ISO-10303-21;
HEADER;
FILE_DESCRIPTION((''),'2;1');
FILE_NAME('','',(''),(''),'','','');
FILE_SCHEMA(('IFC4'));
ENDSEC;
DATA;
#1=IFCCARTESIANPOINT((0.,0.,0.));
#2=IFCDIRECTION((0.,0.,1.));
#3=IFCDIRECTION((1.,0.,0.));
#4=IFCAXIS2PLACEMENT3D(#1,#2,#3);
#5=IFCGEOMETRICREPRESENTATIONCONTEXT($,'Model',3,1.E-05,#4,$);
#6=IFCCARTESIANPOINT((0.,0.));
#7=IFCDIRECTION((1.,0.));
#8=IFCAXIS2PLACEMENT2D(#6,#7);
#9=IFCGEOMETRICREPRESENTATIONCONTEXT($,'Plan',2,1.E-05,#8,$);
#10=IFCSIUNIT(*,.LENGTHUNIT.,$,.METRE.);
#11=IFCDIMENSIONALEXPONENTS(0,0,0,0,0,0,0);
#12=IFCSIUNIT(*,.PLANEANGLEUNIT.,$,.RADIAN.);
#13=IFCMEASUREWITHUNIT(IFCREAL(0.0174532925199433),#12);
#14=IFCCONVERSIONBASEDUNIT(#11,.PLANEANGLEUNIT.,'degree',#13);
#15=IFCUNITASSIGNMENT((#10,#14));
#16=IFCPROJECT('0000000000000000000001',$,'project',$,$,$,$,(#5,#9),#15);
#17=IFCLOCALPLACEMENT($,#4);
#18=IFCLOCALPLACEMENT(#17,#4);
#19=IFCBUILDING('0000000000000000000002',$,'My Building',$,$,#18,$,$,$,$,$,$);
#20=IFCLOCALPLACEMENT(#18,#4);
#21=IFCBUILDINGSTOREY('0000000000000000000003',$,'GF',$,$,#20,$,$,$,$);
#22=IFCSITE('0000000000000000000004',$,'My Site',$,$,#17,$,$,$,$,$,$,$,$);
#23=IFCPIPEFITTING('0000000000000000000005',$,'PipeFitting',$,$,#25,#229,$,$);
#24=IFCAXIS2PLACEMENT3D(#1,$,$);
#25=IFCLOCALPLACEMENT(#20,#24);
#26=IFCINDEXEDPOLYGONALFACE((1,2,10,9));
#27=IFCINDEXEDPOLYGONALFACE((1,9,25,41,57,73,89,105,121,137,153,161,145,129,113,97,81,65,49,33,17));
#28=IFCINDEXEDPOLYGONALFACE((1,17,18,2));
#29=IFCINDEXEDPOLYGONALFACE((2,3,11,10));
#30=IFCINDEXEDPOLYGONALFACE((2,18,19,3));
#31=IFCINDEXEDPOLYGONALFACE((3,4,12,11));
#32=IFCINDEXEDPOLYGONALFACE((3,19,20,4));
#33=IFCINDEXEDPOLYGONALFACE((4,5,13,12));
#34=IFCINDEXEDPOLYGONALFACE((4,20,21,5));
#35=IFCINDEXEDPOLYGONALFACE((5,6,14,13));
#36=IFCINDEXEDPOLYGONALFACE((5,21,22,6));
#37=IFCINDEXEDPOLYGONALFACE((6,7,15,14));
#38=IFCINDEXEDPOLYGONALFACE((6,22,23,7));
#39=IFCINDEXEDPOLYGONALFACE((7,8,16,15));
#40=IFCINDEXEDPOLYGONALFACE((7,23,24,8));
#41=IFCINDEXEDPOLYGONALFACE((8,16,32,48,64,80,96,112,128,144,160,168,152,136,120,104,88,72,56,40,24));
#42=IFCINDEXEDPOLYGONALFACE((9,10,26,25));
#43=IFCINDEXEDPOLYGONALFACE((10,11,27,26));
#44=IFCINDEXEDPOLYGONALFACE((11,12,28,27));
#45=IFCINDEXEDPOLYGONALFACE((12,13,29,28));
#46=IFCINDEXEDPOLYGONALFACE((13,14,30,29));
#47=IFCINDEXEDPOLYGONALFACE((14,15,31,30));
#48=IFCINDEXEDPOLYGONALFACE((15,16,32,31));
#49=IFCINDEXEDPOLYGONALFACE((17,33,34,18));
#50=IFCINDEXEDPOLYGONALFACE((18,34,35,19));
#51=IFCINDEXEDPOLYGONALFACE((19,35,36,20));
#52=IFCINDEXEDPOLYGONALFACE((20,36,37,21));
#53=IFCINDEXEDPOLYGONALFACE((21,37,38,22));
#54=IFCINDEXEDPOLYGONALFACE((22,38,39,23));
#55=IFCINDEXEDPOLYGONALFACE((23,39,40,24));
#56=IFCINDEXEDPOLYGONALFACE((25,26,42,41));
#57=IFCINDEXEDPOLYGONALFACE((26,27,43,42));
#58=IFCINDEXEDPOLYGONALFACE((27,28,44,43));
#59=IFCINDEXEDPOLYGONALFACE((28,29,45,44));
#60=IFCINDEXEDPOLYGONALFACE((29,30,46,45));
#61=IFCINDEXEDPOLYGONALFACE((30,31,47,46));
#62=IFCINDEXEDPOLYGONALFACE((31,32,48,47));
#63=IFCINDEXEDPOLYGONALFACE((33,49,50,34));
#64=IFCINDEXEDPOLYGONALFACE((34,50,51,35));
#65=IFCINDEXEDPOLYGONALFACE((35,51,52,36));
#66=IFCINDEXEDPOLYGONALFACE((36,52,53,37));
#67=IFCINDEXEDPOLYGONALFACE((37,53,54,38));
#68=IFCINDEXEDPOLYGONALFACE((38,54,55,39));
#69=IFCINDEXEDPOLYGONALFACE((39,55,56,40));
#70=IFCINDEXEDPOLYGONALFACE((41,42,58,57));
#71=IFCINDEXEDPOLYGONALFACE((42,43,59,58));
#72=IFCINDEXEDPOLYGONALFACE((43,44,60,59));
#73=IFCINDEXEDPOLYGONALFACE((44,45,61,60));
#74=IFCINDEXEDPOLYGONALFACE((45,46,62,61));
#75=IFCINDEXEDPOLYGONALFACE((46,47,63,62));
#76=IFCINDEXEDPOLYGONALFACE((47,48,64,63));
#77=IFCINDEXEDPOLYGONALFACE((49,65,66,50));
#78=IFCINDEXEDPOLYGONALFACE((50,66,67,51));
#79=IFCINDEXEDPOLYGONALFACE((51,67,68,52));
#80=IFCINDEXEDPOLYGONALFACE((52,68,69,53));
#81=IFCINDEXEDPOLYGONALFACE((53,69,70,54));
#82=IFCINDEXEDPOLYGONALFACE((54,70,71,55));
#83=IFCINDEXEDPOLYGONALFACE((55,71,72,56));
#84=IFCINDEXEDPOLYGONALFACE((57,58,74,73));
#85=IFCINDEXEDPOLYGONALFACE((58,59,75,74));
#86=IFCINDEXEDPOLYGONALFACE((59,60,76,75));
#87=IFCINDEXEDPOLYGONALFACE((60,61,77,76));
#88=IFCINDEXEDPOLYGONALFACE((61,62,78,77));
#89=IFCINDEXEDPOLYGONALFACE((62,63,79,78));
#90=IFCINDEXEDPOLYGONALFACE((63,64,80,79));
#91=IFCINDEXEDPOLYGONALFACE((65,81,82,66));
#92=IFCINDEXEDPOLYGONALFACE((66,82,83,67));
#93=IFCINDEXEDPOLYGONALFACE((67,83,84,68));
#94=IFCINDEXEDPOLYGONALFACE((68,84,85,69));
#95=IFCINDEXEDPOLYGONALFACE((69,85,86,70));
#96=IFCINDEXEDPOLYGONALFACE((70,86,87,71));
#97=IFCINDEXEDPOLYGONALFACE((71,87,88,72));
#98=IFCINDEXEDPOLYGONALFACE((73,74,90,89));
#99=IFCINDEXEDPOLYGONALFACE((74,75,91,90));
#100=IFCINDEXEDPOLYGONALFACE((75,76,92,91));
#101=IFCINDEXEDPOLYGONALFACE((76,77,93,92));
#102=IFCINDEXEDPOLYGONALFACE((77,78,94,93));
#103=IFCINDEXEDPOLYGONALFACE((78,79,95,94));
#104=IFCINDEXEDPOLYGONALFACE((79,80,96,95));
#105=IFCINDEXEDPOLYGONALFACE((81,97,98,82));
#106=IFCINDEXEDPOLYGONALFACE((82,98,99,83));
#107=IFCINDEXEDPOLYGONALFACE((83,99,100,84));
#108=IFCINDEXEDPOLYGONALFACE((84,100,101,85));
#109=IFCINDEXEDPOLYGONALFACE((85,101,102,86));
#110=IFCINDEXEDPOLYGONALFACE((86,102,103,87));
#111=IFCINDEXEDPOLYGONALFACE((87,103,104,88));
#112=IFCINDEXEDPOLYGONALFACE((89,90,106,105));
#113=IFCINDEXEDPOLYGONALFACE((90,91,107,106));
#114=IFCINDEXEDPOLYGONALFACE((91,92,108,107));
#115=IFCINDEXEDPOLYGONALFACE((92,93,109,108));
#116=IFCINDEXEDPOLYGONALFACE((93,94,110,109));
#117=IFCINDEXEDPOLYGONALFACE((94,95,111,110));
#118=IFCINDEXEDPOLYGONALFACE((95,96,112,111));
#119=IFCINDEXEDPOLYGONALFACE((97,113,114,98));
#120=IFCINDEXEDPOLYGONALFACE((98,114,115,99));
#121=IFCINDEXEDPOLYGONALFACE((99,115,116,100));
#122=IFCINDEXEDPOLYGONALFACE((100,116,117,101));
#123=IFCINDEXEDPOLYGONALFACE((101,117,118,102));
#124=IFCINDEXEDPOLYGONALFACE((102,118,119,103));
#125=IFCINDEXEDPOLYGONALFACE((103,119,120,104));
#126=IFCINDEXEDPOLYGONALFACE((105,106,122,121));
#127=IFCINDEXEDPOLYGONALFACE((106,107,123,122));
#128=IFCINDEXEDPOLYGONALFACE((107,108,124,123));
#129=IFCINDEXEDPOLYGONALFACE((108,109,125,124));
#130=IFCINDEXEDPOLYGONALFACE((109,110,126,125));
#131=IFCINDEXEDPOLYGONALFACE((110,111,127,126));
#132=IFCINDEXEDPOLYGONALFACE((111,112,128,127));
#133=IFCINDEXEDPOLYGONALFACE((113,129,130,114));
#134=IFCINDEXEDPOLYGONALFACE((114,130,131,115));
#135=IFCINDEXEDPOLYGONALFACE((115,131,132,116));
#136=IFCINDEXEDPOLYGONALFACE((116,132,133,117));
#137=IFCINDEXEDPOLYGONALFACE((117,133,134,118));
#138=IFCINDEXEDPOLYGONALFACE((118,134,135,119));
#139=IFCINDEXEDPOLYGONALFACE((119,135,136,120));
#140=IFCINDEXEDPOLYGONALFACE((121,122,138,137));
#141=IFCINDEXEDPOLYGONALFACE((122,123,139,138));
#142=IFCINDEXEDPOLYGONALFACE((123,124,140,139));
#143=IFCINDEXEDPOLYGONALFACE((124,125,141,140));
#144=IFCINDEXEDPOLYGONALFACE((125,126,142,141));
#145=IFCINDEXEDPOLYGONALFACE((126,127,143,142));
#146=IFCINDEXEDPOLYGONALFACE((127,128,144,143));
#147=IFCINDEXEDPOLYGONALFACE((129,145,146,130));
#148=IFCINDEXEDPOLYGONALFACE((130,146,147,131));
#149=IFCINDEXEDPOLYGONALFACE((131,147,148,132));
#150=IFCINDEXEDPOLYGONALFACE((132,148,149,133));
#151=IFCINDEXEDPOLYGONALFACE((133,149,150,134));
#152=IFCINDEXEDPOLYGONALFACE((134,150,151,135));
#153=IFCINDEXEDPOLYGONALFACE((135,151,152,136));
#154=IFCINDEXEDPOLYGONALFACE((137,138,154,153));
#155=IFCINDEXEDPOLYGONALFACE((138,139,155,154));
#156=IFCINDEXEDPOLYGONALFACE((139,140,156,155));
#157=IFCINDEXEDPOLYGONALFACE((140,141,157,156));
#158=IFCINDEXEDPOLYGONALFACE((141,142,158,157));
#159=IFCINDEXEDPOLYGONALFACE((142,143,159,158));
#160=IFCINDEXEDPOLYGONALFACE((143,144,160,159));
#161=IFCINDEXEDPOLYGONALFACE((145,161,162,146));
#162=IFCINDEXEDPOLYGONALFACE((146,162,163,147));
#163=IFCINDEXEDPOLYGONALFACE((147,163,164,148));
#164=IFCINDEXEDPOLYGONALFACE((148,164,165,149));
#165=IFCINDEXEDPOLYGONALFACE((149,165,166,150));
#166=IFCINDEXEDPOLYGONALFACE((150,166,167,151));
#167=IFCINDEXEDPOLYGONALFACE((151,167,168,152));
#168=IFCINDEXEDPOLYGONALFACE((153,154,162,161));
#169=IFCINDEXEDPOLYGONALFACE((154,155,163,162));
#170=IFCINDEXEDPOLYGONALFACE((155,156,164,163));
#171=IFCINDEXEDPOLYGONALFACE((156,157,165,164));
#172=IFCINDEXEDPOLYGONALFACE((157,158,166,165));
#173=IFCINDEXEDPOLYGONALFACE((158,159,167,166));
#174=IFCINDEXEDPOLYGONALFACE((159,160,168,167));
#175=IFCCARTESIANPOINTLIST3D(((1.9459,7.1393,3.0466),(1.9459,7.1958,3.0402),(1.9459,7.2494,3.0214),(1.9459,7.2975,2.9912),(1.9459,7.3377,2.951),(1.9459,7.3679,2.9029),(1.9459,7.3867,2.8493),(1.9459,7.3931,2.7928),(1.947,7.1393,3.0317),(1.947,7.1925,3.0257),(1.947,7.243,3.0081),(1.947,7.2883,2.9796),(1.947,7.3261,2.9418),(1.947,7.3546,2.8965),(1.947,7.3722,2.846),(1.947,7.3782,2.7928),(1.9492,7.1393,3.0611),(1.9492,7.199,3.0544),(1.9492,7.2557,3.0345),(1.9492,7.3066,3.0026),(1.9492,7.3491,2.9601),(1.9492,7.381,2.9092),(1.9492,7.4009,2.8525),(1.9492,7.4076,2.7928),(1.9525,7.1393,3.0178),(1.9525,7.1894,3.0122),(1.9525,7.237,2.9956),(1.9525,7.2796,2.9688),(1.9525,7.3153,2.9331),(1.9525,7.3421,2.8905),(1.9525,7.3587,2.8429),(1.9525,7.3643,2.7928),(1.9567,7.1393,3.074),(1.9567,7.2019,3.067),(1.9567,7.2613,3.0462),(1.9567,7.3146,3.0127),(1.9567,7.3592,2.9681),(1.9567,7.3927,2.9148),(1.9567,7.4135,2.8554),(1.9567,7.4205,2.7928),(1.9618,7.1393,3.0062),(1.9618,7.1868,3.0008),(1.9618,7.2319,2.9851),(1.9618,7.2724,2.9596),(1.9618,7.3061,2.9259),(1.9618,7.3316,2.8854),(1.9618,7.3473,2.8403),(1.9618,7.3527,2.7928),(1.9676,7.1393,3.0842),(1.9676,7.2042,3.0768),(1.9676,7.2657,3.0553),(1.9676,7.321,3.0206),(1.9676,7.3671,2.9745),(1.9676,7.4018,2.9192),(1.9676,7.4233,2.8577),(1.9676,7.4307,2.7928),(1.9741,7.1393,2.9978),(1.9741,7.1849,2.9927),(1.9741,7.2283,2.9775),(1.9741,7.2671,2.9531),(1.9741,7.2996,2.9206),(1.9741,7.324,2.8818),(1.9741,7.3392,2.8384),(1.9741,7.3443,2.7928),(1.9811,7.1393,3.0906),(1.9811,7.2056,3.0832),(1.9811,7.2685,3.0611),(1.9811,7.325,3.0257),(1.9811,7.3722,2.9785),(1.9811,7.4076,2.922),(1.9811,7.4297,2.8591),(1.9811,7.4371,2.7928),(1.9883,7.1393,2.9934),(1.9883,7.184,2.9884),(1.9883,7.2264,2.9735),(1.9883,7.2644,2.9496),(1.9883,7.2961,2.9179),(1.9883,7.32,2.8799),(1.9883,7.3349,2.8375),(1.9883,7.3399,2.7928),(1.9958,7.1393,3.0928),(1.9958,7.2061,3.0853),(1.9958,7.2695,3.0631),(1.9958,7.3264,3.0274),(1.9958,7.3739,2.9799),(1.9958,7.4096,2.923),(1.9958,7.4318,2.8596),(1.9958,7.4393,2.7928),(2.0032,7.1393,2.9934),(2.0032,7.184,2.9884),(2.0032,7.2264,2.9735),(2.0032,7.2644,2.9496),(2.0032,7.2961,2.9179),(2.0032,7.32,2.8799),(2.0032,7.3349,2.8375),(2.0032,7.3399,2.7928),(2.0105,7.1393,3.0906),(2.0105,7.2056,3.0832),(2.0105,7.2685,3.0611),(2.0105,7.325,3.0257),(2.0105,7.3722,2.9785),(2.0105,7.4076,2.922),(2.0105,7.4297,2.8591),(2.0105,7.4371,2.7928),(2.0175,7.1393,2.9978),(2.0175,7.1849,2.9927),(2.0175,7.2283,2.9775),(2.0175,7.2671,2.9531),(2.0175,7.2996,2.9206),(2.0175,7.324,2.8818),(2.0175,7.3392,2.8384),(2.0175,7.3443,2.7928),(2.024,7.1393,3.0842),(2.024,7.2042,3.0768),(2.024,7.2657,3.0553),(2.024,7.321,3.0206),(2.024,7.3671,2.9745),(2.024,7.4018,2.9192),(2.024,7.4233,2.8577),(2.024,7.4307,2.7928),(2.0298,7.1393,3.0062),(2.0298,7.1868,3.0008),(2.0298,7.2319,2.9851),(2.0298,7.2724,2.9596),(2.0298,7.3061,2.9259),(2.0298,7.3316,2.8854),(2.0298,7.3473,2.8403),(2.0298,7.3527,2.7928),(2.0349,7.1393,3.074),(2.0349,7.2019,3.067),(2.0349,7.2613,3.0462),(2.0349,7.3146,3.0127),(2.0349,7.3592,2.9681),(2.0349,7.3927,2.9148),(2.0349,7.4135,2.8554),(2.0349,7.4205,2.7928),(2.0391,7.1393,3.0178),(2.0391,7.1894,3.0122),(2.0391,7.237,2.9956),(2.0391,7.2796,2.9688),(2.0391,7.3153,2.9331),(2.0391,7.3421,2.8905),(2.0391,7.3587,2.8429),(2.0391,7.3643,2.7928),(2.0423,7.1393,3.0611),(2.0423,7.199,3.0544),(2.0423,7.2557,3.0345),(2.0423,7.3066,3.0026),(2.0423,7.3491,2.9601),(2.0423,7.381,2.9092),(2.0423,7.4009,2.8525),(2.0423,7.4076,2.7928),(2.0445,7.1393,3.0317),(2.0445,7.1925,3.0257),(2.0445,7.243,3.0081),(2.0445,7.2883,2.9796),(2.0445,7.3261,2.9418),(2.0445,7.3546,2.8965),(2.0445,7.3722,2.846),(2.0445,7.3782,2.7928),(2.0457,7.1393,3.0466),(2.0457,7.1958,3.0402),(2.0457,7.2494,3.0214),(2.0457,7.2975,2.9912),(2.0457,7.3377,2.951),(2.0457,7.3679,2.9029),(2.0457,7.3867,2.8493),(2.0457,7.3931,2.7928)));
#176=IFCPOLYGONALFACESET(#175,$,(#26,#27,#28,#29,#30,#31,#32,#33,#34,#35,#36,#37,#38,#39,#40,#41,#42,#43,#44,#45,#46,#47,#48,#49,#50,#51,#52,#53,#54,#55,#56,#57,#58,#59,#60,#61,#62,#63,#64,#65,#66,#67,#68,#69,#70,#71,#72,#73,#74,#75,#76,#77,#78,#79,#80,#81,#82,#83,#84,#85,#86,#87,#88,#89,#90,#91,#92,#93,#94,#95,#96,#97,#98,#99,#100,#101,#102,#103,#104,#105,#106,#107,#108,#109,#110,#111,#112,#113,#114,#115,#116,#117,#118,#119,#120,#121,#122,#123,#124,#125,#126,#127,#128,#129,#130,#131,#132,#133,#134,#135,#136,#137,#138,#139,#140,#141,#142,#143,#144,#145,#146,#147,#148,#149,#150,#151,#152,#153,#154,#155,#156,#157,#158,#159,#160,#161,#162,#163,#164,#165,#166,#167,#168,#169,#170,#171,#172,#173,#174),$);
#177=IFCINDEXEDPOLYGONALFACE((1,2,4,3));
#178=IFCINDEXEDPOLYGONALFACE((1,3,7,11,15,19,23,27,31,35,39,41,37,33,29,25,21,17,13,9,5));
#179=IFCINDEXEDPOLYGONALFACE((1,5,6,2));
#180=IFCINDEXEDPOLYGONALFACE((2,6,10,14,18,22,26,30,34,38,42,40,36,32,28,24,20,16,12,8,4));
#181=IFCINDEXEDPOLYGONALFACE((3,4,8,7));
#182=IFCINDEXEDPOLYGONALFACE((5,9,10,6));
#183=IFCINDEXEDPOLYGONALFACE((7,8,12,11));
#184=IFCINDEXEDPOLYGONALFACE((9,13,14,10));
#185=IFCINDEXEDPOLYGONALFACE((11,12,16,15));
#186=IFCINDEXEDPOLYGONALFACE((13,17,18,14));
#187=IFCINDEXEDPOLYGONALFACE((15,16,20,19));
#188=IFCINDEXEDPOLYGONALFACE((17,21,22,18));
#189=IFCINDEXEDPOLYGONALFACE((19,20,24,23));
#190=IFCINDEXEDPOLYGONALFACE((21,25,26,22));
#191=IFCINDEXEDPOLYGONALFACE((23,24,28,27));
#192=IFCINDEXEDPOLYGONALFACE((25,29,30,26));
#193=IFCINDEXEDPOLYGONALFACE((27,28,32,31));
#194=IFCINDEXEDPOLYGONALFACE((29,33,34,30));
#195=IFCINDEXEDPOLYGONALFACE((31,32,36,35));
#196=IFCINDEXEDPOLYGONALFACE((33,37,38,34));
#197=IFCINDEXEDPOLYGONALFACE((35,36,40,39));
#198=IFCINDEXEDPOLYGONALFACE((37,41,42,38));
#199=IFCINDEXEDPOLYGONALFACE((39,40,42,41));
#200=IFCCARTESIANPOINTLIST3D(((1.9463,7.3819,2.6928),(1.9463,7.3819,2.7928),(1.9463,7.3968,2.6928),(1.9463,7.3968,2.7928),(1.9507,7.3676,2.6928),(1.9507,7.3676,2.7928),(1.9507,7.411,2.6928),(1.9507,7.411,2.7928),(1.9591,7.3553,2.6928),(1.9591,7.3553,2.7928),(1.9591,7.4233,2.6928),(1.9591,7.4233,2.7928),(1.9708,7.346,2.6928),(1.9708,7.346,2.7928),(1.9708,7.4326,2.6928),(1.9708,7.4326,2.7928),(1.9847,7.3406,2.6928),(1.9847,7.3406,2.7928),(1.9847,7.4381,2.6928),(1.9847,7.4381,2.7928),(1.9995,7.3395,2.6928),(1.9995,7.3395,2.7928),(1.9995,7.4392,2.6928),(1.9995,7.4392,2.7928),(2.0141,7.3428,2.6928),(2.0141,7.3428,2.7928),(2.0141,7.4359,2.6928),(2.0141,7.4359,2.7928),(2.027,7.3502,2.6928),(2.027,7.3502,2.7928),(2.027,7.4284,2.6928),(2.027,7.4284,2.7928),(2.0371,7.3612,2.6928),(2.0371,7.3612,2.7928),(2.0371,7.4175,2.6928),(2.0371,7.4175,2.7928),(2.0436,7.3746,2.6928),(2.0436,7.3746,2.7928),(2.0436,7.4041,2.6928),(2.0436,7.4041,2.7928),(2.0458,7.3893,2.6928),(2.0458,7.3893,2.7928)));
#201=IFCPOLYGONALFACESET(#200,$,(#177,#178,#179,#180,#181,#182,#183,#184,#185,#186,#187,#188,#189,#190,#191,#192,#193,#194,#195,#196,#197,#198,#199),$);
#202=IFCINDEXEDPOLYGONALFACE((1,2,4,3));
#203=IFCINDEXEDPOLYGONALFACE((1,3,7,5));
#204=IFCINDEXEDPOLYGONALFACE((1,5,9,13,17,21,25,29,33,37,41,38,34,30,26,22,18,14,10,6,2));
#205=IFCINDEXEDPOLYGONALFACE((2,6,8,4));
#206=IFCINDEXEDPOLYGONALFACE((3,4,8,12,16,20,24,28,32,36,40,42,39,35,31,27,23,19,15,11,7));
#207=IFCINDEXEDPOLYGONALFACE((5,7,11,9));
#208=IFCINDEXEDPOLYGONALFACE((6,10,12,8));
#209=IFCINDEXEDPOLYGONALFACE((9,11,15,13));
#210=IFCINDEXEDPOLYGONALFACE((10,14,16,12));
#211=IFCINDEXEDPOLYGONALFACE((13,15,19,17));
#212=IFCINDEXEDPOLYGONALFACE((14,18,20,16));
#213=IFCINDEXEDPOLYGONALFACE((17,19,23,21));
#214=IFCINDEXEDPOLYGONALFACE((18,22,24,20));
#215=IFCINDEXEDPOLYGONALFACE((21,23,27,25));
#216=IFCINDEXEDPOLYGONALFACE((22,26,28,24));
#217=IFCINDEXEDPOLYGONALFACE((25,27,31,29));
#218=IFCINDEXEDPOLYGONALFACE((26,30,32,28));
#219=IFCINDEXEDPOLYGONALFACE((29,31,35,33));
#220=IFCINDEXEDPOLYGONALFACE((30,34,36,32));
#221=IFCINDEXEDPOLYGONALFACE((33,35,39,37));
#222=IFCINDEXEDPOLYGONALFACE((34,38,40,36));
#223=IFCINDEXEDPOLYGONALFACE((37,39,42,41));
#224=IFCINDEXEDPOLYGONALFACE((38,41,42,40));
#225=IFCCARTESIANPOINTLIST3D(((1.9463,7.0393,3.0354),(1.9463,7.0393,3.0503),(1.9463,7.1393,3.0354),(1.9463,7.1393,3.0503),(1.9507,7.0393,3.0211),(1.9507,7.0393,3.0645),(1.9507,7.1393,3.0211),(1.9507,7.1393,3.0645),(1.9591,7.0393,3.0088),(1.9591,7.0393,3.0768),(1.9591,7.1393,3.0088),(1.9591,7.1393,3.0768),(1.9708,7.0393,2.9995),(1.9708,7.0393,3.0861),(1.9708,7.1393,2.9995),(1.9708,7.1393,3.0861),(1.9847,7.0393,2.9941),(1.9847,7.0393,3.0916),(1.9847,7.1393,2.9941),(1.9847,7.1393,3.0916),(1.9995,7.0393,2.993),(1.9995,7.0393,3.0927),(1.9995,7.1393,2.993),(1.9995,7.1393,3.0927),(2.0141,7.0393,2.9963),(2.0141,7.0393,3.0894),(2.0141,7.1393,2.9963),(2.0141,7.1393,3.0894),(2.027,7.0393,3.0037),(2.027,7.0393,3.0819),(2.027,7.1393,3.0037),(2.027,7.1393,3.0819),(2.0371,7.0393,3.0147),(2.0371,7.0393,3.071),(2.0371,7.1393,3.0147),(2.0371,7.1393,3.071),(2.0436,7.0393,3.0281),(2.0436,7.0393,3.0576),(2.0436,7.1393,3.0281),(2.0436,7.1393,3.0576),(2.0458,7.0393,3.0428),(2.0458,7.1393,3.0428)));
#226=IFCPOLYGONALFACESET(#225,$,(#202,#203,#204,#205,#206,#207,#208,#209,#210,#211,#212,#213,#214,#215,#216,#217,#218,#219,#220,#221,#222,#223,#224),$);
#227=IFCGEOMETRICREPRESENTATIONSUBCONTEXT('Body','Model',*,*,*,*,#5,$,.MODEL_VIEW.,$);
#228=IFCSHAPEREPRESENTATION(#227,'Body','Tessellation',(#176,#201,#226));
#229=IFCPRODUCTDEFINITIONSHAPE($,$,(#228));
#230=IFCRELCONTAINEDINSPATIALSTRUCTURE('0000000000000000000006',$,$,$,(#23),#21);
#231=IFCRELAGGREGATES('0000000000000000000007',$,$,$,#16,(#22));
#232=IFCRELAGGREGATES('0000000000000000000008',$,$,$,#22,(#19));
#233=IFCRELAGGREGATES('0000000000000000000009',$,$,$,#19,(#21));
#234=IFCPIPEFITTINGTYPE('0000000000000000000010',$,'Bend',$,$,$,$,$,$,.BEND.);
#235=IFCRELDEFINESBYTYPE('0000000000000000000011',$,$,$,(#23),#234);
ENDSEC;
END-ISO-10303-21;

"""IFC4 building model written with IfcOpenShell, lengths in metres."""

from ifc_helpers import new_model, entity, si_unit, converted_unit, frame, origin_with_axes, origin_2d_with_axis, place, context, subcontext, project, spatial, line, indexed_curve, circle, outline, extrude, source, transform, mapped, type_object, type_shapes, element, save


model = new_model("IFC4")

# Units and contexts
model_context = context("Model", 3, precision=1e-05, world=origin_with_axes())
plan_context = context("Plan", 2, precision=1e-05, world=origin_2d_with_axis())
body_context_1 = subcontext(model_context, "Body", "Model", "MODEL_VIEW")
ifc_project = project(units=[si_unit("LENGTHUNIT", "METRE"), converted_unit("PLANEANGLEUNIT", "degree", entity("IfcReal", 0.0174532925199433), si_unit("PLANEANGLEUNIT", "RADIAN"), dimensions=[0, 0, 0, 0, 0, 0, 0])], contexts=[model_context, plan_context])

# Site, building, storey
site_placement = place(None, origin_with_axes())
site = spatial("IfcSite", under=ifc_project, at=site_placement, Name="My Site")
building_placement = place(site_placement, origin_with_axes())
building = spatial("IfcBuilding", under=site, at=building_placement, Name="My Building")
storey_placement = place(building_placement, origin_with_axes())
storey = spatial("IfcBuildingStorey", under=building, at=storey_placement, Name="GF")

# Pipe fitting, opening
pipe_fitting_type = type_object("IfcPipeFittingType", Name="Bend", PredefinedType="BEND")
shared_shape_1 = source(origin_with_axes(), body_context_1, "Body", "SolidModel", [
    entity("IfcSweptDiskSolid", entity("IfcIndexedPolyCurve", entity("IfcCartesianPointList3D", [[0.0, 0.0, 0.1], [0.0, -0.0732, 0.2768], [0.0, -0.25, 0.35]]), [entity("IfcArcIndex", [1, 2, 3])]), 0.05),
    extrude(circle(Radius=0.05), origin_with_axes(), (0.0, 0.0, 1.0), 0.1),
    extrude(circle(Radius=0.05), frame((0.0, -0.25, 0.35), z_axis=(0.0, -1.0, 0.0), x_axis=(1.0, 0.0, 0.0)), (0.0, 0.0, 1.0), 0.1),
])
type_shapes(pipe_fitting_type, [shared_shape_1])
pipe_fitting_1_placement = place(storey_placement, frame((1.9958, 7.3893, 2.6928), z_axis=(0.0, 0.0, 1.0), x_axis=(1.0, 0.0, 0.0)))
pipe_fitting_1 = element("IfcPipeFitting", 1, at=pipe_fitting_1_placement, inside=storey, type_object=pipe_fitting_type, Name="PipeFitting", context=body_context_1, shape_type="MappedRepresentation", body=[
    mapped(shared_shape_1, transform((0.0, 0.0, 0.0), x_axis=(1.0, 0.0, 0.0), y_axis=(0.0, 1.0, 0.0), z_axis=(0.0, 0.0, 1.0), scale=1.0)),
])
opening_1_placement = place(pipe_fitting_1_placement, frame((-1.9958, -7.3893, -2.6928), z_axis=(0.0, 0.0, 1.0), x_axis=(1.0, 0.0, 0.0)))
element("IfcOpeningElement", 2, at=opening_1_placement, cuts=pipe_fitting_1, PredefinedType="OPENING", context=body_context_1, shape_type="SweptSolid", body=[
    extrude(outline(indexed_curve([(0.0, 0.0), (0.5, 0.0), (0.5, 0.5), (0.0, 0.5)], segments=[line(1, 2, 3, 4, 1)])), origin_with_axes(), (0.0, 0.0, 1.0), 0.5),
])

save(model, "model.ifc")
